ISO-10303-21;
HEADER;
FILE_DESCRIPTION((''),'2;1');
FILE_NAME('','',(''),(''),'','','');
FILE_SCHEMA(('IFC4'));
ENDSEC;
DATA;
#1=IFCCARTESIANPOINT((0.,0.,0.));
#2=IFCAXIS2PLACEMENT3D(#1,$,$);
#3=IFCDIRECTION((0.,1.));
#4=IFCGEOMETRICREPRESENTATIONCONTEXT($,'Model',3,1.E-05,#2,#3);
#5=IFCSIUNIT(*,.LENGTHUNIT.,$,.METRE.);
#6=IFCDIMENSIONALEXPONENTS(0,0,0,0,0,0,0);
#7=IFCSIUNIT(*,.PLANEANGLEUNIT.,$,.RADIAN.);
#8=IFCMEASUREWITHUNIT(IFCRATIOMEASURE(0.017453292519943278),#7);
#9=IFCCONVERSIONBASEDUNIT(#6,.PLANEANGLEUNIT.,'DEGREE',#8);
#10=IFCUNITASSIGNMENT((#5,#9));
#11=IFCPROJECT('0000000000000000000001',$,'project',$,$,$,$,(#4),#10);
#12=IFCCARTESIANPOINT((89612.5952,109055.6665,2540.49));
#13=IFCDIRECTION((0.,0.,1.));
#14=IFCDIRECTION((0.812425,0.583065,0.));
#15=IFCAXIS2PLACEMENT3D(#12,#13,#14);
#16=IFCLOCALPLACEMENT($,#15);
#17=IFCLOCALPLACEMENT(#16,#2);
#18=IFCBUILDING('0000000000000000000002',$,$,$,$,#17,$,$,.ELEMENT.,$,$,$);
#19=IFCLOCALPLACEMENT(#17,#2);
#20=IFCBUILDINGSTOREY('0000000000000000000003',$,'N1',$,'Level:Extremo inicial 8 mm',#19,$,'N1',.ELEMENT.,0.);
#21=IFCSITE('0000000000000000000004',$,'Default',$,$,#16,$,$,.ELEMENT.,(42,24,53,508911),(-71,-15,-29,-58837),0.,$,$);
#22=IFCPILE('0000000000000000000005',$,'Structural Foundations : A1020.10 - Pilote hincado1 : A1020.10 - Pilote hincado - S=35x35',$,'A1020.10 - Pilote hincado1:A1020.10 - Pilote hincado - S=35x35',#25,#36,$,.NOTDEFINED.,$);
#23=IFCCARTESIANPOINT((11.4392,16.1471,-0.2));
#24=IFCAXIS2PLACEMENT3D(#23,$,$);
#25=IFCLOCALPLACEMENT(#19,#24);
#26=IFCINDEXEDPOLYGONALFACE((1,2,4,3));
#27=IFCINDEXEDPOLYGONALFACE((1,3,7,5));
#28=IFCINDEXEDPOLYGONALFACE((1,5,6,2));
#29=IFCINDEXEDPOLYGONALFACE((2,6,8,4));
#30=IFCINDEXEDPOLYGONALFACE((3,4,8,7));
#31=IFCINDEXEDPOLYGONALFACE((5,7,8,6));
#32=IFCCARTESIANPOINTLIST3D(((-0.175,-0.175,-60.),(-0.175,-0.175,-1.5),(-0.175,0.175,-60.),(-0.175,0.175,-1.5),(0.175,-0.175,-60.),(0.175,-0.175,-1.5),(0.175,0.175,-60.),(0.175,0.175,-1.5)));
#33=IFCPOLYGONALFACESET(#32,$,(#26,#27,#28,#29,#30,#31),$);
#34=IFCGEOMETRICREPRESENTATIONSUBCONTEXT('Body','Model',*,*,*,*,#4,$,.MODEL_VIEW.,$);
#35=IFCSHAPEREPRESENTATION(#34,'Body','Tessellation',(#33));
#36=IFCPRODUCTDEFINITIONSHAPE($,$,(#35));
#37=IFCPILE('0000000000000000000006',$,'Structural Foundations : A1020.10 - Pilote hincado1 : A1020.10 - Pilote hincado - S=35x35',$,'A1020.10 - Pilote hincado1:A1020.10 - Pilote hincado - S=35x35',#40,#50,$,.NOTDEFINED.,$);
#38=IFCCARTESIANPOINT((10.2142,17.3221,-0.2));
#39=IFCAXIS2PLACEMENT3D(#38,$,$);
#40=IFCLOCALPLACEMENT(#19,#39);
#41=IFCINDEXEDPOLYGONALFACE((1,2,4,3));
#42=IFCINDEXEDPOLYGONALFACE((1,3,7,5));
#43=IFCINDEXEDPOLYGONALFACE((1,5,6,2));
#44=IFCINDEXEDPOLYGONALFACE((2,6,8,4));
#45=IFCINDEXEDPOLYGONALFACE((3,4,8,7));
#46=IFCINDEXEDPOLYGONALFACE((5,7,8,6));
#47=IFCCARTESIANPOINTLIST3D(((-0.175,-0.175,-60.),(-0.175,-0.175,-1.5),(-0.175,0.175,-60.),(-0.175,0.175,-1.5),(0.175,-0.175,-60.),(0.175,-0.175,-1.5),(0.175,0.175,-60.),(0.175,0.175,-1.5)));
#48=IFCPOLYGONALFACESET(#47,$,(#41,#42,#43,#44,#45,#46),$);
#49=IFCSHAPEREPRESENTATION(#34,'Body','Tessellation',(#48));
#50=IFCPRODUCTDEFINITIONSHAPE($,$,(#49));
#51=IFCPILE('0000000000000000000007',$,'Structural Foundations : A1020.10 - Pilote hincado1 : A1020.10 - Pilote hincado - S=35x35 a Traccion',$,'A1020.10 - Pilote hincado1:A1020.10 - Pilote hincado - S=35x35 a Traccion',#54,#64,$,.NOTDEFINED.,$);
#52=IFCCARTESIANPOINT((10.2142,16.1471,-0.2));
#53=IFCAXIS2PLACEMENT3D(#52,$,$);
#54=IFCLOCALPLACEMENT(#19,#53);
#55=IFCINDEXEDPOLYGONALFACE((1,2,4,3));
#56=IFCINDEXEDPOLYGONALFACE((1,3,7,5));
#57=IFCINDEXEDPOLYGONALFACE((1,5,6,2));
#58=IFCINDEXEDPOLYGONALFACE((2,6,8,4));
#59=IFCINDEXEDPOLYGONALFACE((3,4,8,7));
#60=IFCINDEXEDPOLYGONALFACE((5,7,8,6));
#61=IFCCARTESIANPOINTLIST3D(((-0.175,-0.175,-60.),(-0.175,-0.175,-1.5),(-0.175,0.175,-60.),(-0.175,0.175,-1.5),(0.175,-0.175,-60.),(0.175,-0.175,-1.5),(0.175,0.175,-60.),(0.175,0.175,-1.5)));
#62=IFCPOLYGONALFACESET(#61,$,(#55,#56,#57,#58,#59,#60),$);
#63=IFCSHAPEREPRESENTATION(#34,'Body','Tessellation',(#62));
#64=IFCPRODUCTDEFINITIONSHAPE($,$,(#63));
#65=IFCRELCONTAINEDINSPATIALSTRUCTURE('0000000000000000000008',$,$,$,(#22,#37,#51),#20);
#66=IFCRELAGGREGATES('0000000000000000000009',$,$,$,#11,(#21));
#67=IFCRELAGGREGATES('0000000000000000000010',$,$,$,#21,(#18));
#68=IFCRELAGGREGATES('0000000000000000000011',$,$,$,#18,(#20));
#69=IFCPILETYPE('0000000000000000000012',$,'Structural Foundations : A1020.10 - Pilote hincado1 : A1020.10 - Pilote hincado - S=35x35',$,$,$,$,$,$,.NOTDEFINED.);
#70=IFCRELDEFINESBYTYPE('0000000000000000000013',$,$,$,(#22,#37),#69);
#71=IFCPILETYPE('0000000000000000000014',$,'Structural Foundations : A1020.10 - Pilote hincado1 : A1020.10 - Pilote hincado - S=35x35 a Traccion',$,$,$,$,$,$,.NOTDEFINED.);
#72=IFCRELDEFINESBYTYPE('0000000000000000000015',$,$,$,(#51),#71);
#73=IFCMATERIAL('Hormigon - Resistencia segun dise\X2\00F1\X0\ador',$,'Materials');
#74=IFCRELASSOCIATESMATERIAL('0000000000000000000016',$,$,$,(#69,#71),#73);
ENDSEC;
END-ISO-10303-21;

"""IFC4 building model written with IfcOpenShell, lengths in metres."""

from ifc_helpers import new_model, entity, si_unit, converted_unit, direction, frame, origin, origin_2d_with_axis, place, context, subcontext, project, spatial, polyline, segment, composite_curve, rectangle, outline, extrude, source, transform, mapped, material, material_profile, profile_set, type_object, type_shapes, element, save


model = new_model("IFC4")

# Units and contexts
model_context = context("Model", 3, precision=1e-05, world=origin(), true_north=direction((0.0, 1.0)))
body_context = subcontext(model_context, "Body", "Model", "MODEL_VIEW")
ifc_project = project(units=[si_unit("LENGTHUNIT", "METRE"), converted_unit("PLANEANGLEUNIT", "DEGREE", entity("IfcRatioMeasure", 0.017453292519943278), si_unit("PLANEANGLEUNIT", "RADIAN"), dimensions=[0, 0, 0, 0, 0, 0, 0])], contexts=[model_context])

# Site, building, storey
site_placement = place(None, frame((89612.5952, 109055.6665, 2540.49), z_axis=(0.0, 0.0, 1.0), x_axis=(0.812425, 0.583065, 0.0)))
site = spatial("IfcSite", under=ifc_project, at=site_placement, Name="Default", CompositionType="ELEMENT", RefLatitude=(42, 24, 53, 508911), RefLongitude=(-71, -15, -29, -58837), RefElevation=0.0)
building_placement = place(site_placement, origin())
building = spatial("IfcBuilding", under=site, at=building_placement, CompositionType="ELEMENT")
storey_placement = place(building_placement, origin())
storey = spatial("IfcBuildingStorey", under=building, at=storey_placement, Name="N1", ObjectType="Level:Extremo inicial 8 mm", LongName="N1", CompositionType="ELEMENT", Elevation=0.0)

# Piles
ifc_material_1 = material(Name="Hormigon - Resistencia segun diseñador", Category="Materials")
ifc_material_profile_1 = material_profile(ifc_material_1, outline(composite_curve([segment(polyline([(0.175, 0.175, -60.0), (0.175, -0.175, -60.0)]), True, "CONTINUOUS"), segment(polyline([(0.175, -0.175, -60.0), (-0.175, -0.175, -60.0)]), True, "CONTINUOUS"), segment(polyline([(-0.175, -0.175, -60.0), (-0.175, 0.175, -60.0)]), True, "CONTINUOUS"), segment(polyline([(-0.175, 0.175, -60.0), (0.175, 0.175, -60.0)]), True, "CONTINUOUS")], self_intersect=False), kind="CURVE"), Name="A1020.10 - Pilote hincado - S=35x35")
ifc_profile_set_1 = profile_set([ifc_material_profile_1], Name="A1020.10 - Pilote hincado - S=35x35")
pile_type_1 = type_object("IfcPileType", Name="Structural Foundations : A1020.10 - Pilote hincado1 : A1020.10 - Pilote hincado - S=35x35", PredefinedType="NOTDEFINED", material=ifc_profile_set_1)
shared_shape_1 = source(origin(), body_context, "Body", "SweptSolid", [
    extrude(rectangle(XDim=0.35, YDim=0.35, at=origin_2d_with_axis()), frame((0.0, 0.0, -60.0), z_axis=(0.0, 0.0, 1.0), x_axis=(0.0, -1.0, 0.0)), (0.0, 0.0, 1.0), 58.5),
])
type_shapes(pile_type_1, [shared_shape_1])
for number, where, name in (
    (1, (11.4392, 16.1471, -0.2), "Structural Foundations : A1020.10 - Pilote hincado1 : A1020.10 - Pilote hincado - S=35x35"),
    (2, (10.2142, 17.3221, -0.2), "Structural Foundations : A1020.10 - Pilote hincado1 : A1020.10 - Pilote hincado - S=35x35"),
):
    element("IfcPile", number, at=place(storey_placement, frame(where)), inside=storey, type_object=pile_type_1, Name=name, ObjectType="A1020.10 - Pilote hincado1:A1020.10 - Pilote hincado - S=35x35", PredefinedType="NOTDEFINED", context=body_context, shape_type="MappedRepresentation", body=[
        mapped(shared_shape_1, transform((0.0, 0.0, 0.0), scale=1.0)),
    ])
ifc_material_profile_2 = material_profile(ifc_material_1, outline(composite_curve([segment(polyline([(0.175, 0.175, -60.0), (0.175, -0.175, -60.0)]), True, "CONTINUOUS"), segment(polyline([(0.175, -0.175, -60.0), (-0.175, -0.175, -60.0)]), True, "CONTINUOUS"), segment(polyline([(-0.175, -0.175, -60.0), (-0.175, 0.175, -60.0)]), True, "CONTINUOUS"), segment(polyline([(-0.175, 0.175, -60.0), (0.175, 0.175, -60.0)]), True, "CONTINUOUS")], self_intersect=False), kind="CURVE"), Name="A1020.10 - Pilote hincado - S=35x35 a Traccion")
ifc_profile_set_2 = profile_set([ifc_material_profile_2], Name="A1020.10 - Pilote hincado - S=35x35 a Traccion")
pile_type_2 = type_object("IfcPileType", Name="Structural Foundations : A1020.10 - Pilote hincado1 : A1020.10 - Pilote hincado - S=35x35 a Traccion", PredefinedType="NOTDEFINED", material=ifc_profile_set_2)
shared_shape_2 = source(origin(), body_context, "Body", "SweptSolid", [
    extrude(rectangle(XDim=0.35, YDim=0.35, at=origin_2d_with_axis()), frame((0.0, 0.0, -60.0), z_axis=(0.0, 0.0, 1.0), x_axis=(0.0, -1.0, 0.0)), (0.0, 0.0, 1.0), 58.5),
])
type_shapes(pile_type_2, [shared_shape_2])
pile_placement = place(storey_placement, frame((10.2142, 16.1471, -0.2)))
element("IfcPile", 3, at=pile_placement, inside=storey, type_object=pile_type_2, Name="Structural Foundations : A1020.10 - Pilote hincado1 : A1020.10 - Pilote hincado - S=35x35 a Traccion", ObjectType="A1020.10 - Pilote hincado1:A1020.10 - Pilote hincado - S=35x35 a Traccion", PredefinedType="NOTDEFINED", context=body_context, shape_type="MappedRepresentation", body=[
    mapped(shared_shape_2, transform((0.0, 0.0, 0.0), scale=1.0)),
])

save(model, "model.ifc")
